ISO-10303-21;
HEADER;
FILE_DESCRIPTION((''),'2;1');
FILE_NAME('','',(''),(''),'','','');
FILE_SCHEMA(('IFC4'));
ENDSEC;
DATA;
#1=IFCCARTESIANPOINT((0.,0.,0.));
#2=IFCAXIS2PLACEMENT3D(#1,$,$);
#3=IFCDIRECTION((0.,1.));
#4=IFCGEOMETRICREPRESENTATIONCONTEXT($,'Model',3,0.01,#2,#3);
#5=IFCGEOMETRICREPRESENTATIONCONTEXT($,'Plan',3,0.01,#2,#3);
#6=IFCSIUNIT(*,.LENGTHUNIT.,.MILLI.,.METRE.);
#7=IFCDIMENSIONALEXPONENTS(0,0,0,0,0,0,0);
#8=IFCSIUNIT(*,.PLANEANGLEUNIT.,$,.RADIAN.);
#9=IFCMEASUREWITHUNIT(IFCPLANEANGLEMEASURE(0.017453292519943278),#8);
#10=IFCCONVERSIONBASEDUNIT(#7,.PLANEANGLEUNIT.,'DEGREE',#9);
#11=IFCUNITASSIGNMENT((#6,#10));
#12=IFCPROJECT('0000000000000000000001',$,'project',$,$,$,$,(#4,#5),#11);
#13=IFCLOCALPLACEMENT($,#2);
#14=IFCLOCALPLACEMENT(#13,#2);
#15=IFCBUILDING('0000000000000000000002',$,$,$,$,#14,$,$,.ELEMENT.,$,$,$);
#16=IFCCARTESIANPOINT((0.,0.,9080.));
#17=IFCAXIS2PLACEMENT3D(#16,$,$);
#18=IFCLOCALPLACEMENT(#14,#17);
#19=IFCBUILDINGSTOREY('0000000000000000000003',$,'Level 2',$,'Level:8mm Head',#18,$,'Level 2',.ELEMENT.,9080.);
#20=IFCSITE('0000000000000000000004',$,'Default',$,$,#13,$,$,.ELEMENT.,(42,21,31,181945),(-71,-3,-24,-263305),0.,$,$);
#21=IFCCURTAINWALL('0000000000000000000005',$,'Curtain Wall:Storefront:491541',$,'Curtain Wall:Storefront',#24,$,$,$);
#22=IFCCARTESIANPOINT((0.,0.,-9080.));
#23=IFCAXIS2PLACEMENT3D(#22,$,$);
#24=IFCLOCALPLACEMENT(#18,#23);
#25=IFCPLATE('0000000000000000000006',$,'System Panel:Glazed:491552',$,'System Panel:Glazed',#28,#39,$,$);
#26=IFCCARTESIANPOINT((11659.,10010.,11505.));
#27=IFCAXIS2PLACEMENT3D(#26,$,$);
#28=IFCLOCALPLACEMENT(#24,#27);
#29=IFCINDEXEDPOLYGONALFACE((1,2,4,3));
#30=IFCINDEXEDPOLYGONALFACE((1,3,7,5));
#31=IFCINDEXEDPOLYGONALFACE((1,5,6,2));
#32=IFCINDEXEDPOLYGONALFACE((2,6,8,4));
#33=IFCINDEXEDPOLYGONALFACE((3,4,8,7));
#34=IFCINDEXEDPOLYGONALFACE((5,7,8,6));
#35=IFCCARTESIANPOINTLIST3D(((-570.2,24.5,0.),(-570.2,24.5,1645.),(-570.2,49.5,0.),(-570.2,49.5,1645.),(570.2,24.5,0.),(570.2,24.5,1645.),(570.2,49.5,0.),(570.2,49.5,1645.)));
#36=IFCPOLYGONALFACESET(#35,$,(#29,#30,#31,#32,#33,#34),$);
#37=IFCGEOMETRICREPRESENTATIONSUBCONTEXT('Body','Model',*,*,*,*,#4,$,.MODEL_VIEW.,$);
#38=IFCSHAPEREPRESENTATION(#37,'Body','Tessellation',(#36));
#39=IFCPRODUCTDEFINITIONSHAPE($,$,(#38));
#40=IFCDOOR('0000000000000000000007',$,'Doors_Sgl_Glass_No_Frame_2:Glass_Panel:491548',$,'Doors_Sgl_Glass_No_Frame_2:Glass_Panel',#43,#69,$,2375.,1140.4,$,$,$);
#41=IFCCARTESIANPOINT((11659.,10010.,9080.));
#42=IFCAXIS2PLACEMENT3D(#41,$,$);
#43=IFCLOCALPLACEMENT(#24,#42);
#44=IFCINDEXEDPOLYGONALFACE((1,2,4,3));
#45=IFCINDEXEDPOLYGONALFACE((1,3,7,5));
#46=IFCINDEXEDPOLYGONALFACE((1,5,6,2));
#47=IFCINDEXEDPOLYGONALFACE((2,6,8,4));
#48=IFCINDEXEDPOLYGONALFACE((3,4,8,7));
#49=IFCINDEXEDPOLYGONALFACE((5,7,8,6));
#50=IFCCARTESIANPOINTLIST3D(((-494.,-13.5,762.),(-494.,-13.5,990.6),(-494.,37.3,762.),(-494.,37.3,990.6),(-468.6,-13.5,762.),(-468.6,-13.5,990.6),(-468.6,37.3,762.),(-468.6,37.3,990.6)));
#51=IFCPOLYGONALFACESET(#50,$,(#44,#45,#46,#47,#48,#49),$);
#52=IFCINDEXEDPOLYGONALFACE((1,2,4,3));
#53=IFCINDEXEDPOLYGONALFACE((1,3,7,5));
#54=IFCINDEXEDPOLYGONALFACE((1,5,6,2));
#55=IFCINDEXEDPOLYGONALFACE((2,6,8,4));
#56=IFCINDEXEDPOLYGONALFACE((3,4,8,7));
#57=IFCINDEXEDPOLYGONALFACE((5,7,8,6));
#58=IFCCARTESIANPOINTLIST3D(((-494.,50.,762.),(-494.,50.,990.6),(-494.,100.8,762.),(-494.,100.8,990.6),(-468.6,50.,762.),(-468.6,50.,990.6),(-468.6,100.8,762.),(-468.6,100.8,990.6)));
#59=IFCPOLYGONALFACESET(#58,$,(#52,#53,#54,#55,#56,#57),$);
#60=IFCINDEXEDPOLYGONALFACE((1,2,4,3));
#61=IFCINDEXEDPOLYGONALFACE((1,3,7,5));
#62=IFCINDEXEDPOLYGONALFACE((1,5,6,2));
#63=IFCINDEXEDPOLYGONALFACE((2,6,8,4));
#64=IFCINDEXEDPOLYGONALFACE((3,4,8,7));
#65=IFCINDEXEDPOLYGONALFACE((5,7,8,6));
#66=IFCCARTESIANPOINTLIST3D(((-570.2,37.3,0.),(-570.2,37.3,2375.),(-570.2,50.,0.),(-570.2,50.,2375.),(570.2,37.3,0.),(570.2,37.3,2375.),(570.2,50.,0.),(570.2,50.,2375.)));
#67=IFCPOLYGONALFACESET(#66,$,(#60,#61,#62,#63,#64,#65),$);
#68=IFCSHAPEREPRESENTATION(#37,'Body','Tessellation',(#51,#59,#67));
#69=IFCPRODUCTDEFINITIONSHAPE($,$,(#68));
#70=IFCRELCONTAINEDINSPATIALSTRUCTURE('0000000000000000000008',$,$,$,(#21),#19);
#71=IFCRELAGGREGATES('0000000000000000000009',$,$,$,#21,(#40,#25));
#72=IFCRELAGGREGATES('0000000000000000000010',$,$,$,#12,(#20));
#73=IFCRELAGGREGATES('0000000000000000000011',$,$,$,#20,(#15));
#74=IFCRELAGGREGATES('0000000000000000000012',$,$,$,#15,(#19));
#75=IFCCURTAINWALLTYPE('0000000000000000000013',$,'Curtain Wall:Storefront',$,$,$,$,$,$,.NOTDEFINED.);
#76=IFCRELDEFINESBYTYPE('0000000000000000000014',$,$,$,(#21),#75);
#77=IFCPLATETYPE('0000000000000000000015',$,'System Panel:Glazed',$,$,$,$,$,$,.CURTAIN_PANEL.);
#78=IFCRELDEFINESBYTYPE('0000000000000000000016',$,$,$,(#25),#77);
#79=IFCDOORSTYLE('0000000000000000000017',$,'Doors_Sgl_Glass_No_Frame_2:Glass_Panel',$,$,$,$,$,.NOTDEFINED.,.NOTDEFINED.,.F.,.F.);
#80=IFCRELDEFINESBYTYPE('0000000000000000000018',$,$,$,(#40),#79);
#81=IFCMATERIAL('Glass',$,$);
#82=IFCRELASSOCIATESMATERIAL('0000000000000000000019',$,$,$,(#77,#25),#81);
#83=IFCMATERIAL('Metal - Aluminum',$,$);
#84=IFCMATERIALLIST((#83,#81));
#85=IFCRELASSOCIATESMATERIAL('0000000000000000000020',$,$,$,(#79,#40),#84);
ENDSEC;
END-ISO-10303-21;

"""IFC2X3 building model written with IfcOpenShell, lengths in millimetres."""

from ifc_helpers import new_model, entity, si_unit, converted_unit, direction, frame, frame_2d, origin, origin_2d_with_axis, place, context, subcontext, project, spatial, rectangle, extrude, source, transform, mapped, material, material_list, type_object, type_shapes, element, aggregate, save


model = new_model("IFC2X3")

# Units and contexts
model_context = context("Model", 3, precision=0.01, world=origin(), true_north=direction((0.0, 1.0)))
plan_context = context("Plan", 3, precision=0.01, world=origin(), true_north=direction((0.0, 1.0)))
body_context = subcontext(model_context, "Body", "Model", "MODEL_VIEW")
ifc_project = project(units=[si_unit("LENGTHUNIT", "METRE", prefix="MILLI"), converted_unit("PLANEANGLEUNIT", "DEGREE", entity("IfcPlaneAngleMeasure", 0.017453292519943278), si_unit("PLANEANGLEUNIT", "RADIAN"), dimensions=[0, 0, 0, 0, 0, 0, 0])], contexts=[model_context, plan_context])

# Site, building, storey
site_placement = place(None, origin())
site = spatial("IfcSite", under=ifc_project, at=site_placement, Name="Default", CompositionType="ELEMENT", RefLatitude=(42, 21, 31, 181945), RefLongitude=(-71, -3, -24, -263305), RefElevation=0.0)
building_placement = place(site_placement, origin())
building = spatial("IfcBuilding", under=site, at=building_placement, CompositionType="ELEMENT")
storey_placement = place(building_placement, frame((0.0, 0.0, 9080.0)))
storey = spatial("IfcBuildingStorey", under=building, at=storey_placement, Name="Level 2", ObjectType="Level:8mm Head", LongName="Level 2", CompositionType="ELEMENT", Elevation=9080.0)

# Curtain wall
curtain_wall_type = type_object("IfcCurtainWallType", Name="Curtain Wall:Storefront", PredefinedType="NOTDEFINED")
curtain_wall_1_placement = place(storey_placement, frame((0.0, 0.0, -9080.0)))
curtain_wall_1 = element("IfcCurtainWall", 1, at=curtain_wall_1_placement, inside=storey, type_object=curtain_wall_type, Name="Curtain Wall:Storefront:491541", ObjectType="Curtain Wall:Storefront")

# Plate
ifc_material_1 = material(Name="Glass")
plate_type = type_object("IfcPlateType", Name="System Panel:Glazed", PredefinedType="CURTAIN_PANEL", material=ifc_material_1)
shared_shape_1 = source(origin(), body_context, "Body", "SweptSolid", [
    extrude(rectangle(XDim=25.0, YDim=1140.4, at=origin_2d_with_axis()), frame((0.0, 37.0, 0.0), z_axis=(0.0, 0.0, 1.0), x_axis=(0.0, 1.0, 0.0)), (0.0, 0.0, 1.0), 1645.0),
])
type_shapes(plate_type, [shared_shape_1])
plate_placement = place(curtain_wall_1_placement, frame((11659.0, 10010.0, 11505.0)))
plate = element("IfcPlate", 2, at=plate_placement, type_object=plate_type, material=ifc_material_1, Name="System Panel:Glazed:491552", ObjectType="System Panel:Glazed", context=body_context, shape_type="MappedRepresentation", body=[
    mapped(shared_shape_1, transform((0.0, 0.0, 0.0), scale=1.0)),
])

# Door
ifc_material_2 = material(Name="Metal - Aluminum")
ifc_material_list = material_list([ifc_material_2, ifc_material_1])
door_style = type_object("IfcDoorStyle", Name="Doors_Sgl_Glass_No_Frame_2:Glass_Panel", ConstructionType="NOTDEFINED", OperationType="NOTDEFINED", ParameterTakesPrecedence=False, Sizeable=False, material=ifc_material_list)
shared_shape_2 = source(origin(), body_context, "Body", "SweptSolid", [
    extrude(rectangle(XDim=50.8, YDim=25.4, at=origin_2d_with_axis()), frame((-481.3, 11.9, 762.0), z_axis=(0.0, 0.0, 1.0), x_axis=(0.0, 1.0, 0.0)), (0.0, 0.0, 1.0), 228.6),
    extrude(rectangle(XDim=50.8, YDim=25.4, at=frame_2d((0.0, 0.0), x_axis=(1.0, 0.0))), frame((-481.3, 75.4, 762.0), z_axis=(0.0, 0.0, 1.0), x_axis=(0.0, -1.0, 0.0)), (0.0, 0.0, 1.0), 228.6),
    extrude(rectangle(XDim=1140.4, YDim=12.7, at=frame_2d((0.0, 0.0), x_axis=(1.0, 0.0))), frame((0.0, 43.7, 0.0), z_axis=(0.0, 0.0, 1.0), x_axis=(-1.0, 0.0, 0.0)), (0.0, 0.0, 1.0), 2375.0),
])
type_shapes(door_style, [shared_shape_2])
door_placement = place(curtain_wall_1_placement, frame((11659.0, 10010.0, 9080.0)))
door = element("IfcDoor", 3, at=door_placement, type_object=door_style, material=ifc_material_list, Name="Doors_Sgl_Glass_No_Frame_2:Glass_Panel:491548", ObjectType="Doors_Sgl_Glass_No_Frame_2:Glass_Panel", OverallHeight=2375.0, OverallWidth=1140.4, context=body_context, shape_type="MappedRepresentation", body=[
    mapped(shared_shape_2, transform((0.0, 0.0, 0.0), scale=1.0)),
])
aggregate(curtain_wall_1, [door, plate])

save(model, "model.ifc")
